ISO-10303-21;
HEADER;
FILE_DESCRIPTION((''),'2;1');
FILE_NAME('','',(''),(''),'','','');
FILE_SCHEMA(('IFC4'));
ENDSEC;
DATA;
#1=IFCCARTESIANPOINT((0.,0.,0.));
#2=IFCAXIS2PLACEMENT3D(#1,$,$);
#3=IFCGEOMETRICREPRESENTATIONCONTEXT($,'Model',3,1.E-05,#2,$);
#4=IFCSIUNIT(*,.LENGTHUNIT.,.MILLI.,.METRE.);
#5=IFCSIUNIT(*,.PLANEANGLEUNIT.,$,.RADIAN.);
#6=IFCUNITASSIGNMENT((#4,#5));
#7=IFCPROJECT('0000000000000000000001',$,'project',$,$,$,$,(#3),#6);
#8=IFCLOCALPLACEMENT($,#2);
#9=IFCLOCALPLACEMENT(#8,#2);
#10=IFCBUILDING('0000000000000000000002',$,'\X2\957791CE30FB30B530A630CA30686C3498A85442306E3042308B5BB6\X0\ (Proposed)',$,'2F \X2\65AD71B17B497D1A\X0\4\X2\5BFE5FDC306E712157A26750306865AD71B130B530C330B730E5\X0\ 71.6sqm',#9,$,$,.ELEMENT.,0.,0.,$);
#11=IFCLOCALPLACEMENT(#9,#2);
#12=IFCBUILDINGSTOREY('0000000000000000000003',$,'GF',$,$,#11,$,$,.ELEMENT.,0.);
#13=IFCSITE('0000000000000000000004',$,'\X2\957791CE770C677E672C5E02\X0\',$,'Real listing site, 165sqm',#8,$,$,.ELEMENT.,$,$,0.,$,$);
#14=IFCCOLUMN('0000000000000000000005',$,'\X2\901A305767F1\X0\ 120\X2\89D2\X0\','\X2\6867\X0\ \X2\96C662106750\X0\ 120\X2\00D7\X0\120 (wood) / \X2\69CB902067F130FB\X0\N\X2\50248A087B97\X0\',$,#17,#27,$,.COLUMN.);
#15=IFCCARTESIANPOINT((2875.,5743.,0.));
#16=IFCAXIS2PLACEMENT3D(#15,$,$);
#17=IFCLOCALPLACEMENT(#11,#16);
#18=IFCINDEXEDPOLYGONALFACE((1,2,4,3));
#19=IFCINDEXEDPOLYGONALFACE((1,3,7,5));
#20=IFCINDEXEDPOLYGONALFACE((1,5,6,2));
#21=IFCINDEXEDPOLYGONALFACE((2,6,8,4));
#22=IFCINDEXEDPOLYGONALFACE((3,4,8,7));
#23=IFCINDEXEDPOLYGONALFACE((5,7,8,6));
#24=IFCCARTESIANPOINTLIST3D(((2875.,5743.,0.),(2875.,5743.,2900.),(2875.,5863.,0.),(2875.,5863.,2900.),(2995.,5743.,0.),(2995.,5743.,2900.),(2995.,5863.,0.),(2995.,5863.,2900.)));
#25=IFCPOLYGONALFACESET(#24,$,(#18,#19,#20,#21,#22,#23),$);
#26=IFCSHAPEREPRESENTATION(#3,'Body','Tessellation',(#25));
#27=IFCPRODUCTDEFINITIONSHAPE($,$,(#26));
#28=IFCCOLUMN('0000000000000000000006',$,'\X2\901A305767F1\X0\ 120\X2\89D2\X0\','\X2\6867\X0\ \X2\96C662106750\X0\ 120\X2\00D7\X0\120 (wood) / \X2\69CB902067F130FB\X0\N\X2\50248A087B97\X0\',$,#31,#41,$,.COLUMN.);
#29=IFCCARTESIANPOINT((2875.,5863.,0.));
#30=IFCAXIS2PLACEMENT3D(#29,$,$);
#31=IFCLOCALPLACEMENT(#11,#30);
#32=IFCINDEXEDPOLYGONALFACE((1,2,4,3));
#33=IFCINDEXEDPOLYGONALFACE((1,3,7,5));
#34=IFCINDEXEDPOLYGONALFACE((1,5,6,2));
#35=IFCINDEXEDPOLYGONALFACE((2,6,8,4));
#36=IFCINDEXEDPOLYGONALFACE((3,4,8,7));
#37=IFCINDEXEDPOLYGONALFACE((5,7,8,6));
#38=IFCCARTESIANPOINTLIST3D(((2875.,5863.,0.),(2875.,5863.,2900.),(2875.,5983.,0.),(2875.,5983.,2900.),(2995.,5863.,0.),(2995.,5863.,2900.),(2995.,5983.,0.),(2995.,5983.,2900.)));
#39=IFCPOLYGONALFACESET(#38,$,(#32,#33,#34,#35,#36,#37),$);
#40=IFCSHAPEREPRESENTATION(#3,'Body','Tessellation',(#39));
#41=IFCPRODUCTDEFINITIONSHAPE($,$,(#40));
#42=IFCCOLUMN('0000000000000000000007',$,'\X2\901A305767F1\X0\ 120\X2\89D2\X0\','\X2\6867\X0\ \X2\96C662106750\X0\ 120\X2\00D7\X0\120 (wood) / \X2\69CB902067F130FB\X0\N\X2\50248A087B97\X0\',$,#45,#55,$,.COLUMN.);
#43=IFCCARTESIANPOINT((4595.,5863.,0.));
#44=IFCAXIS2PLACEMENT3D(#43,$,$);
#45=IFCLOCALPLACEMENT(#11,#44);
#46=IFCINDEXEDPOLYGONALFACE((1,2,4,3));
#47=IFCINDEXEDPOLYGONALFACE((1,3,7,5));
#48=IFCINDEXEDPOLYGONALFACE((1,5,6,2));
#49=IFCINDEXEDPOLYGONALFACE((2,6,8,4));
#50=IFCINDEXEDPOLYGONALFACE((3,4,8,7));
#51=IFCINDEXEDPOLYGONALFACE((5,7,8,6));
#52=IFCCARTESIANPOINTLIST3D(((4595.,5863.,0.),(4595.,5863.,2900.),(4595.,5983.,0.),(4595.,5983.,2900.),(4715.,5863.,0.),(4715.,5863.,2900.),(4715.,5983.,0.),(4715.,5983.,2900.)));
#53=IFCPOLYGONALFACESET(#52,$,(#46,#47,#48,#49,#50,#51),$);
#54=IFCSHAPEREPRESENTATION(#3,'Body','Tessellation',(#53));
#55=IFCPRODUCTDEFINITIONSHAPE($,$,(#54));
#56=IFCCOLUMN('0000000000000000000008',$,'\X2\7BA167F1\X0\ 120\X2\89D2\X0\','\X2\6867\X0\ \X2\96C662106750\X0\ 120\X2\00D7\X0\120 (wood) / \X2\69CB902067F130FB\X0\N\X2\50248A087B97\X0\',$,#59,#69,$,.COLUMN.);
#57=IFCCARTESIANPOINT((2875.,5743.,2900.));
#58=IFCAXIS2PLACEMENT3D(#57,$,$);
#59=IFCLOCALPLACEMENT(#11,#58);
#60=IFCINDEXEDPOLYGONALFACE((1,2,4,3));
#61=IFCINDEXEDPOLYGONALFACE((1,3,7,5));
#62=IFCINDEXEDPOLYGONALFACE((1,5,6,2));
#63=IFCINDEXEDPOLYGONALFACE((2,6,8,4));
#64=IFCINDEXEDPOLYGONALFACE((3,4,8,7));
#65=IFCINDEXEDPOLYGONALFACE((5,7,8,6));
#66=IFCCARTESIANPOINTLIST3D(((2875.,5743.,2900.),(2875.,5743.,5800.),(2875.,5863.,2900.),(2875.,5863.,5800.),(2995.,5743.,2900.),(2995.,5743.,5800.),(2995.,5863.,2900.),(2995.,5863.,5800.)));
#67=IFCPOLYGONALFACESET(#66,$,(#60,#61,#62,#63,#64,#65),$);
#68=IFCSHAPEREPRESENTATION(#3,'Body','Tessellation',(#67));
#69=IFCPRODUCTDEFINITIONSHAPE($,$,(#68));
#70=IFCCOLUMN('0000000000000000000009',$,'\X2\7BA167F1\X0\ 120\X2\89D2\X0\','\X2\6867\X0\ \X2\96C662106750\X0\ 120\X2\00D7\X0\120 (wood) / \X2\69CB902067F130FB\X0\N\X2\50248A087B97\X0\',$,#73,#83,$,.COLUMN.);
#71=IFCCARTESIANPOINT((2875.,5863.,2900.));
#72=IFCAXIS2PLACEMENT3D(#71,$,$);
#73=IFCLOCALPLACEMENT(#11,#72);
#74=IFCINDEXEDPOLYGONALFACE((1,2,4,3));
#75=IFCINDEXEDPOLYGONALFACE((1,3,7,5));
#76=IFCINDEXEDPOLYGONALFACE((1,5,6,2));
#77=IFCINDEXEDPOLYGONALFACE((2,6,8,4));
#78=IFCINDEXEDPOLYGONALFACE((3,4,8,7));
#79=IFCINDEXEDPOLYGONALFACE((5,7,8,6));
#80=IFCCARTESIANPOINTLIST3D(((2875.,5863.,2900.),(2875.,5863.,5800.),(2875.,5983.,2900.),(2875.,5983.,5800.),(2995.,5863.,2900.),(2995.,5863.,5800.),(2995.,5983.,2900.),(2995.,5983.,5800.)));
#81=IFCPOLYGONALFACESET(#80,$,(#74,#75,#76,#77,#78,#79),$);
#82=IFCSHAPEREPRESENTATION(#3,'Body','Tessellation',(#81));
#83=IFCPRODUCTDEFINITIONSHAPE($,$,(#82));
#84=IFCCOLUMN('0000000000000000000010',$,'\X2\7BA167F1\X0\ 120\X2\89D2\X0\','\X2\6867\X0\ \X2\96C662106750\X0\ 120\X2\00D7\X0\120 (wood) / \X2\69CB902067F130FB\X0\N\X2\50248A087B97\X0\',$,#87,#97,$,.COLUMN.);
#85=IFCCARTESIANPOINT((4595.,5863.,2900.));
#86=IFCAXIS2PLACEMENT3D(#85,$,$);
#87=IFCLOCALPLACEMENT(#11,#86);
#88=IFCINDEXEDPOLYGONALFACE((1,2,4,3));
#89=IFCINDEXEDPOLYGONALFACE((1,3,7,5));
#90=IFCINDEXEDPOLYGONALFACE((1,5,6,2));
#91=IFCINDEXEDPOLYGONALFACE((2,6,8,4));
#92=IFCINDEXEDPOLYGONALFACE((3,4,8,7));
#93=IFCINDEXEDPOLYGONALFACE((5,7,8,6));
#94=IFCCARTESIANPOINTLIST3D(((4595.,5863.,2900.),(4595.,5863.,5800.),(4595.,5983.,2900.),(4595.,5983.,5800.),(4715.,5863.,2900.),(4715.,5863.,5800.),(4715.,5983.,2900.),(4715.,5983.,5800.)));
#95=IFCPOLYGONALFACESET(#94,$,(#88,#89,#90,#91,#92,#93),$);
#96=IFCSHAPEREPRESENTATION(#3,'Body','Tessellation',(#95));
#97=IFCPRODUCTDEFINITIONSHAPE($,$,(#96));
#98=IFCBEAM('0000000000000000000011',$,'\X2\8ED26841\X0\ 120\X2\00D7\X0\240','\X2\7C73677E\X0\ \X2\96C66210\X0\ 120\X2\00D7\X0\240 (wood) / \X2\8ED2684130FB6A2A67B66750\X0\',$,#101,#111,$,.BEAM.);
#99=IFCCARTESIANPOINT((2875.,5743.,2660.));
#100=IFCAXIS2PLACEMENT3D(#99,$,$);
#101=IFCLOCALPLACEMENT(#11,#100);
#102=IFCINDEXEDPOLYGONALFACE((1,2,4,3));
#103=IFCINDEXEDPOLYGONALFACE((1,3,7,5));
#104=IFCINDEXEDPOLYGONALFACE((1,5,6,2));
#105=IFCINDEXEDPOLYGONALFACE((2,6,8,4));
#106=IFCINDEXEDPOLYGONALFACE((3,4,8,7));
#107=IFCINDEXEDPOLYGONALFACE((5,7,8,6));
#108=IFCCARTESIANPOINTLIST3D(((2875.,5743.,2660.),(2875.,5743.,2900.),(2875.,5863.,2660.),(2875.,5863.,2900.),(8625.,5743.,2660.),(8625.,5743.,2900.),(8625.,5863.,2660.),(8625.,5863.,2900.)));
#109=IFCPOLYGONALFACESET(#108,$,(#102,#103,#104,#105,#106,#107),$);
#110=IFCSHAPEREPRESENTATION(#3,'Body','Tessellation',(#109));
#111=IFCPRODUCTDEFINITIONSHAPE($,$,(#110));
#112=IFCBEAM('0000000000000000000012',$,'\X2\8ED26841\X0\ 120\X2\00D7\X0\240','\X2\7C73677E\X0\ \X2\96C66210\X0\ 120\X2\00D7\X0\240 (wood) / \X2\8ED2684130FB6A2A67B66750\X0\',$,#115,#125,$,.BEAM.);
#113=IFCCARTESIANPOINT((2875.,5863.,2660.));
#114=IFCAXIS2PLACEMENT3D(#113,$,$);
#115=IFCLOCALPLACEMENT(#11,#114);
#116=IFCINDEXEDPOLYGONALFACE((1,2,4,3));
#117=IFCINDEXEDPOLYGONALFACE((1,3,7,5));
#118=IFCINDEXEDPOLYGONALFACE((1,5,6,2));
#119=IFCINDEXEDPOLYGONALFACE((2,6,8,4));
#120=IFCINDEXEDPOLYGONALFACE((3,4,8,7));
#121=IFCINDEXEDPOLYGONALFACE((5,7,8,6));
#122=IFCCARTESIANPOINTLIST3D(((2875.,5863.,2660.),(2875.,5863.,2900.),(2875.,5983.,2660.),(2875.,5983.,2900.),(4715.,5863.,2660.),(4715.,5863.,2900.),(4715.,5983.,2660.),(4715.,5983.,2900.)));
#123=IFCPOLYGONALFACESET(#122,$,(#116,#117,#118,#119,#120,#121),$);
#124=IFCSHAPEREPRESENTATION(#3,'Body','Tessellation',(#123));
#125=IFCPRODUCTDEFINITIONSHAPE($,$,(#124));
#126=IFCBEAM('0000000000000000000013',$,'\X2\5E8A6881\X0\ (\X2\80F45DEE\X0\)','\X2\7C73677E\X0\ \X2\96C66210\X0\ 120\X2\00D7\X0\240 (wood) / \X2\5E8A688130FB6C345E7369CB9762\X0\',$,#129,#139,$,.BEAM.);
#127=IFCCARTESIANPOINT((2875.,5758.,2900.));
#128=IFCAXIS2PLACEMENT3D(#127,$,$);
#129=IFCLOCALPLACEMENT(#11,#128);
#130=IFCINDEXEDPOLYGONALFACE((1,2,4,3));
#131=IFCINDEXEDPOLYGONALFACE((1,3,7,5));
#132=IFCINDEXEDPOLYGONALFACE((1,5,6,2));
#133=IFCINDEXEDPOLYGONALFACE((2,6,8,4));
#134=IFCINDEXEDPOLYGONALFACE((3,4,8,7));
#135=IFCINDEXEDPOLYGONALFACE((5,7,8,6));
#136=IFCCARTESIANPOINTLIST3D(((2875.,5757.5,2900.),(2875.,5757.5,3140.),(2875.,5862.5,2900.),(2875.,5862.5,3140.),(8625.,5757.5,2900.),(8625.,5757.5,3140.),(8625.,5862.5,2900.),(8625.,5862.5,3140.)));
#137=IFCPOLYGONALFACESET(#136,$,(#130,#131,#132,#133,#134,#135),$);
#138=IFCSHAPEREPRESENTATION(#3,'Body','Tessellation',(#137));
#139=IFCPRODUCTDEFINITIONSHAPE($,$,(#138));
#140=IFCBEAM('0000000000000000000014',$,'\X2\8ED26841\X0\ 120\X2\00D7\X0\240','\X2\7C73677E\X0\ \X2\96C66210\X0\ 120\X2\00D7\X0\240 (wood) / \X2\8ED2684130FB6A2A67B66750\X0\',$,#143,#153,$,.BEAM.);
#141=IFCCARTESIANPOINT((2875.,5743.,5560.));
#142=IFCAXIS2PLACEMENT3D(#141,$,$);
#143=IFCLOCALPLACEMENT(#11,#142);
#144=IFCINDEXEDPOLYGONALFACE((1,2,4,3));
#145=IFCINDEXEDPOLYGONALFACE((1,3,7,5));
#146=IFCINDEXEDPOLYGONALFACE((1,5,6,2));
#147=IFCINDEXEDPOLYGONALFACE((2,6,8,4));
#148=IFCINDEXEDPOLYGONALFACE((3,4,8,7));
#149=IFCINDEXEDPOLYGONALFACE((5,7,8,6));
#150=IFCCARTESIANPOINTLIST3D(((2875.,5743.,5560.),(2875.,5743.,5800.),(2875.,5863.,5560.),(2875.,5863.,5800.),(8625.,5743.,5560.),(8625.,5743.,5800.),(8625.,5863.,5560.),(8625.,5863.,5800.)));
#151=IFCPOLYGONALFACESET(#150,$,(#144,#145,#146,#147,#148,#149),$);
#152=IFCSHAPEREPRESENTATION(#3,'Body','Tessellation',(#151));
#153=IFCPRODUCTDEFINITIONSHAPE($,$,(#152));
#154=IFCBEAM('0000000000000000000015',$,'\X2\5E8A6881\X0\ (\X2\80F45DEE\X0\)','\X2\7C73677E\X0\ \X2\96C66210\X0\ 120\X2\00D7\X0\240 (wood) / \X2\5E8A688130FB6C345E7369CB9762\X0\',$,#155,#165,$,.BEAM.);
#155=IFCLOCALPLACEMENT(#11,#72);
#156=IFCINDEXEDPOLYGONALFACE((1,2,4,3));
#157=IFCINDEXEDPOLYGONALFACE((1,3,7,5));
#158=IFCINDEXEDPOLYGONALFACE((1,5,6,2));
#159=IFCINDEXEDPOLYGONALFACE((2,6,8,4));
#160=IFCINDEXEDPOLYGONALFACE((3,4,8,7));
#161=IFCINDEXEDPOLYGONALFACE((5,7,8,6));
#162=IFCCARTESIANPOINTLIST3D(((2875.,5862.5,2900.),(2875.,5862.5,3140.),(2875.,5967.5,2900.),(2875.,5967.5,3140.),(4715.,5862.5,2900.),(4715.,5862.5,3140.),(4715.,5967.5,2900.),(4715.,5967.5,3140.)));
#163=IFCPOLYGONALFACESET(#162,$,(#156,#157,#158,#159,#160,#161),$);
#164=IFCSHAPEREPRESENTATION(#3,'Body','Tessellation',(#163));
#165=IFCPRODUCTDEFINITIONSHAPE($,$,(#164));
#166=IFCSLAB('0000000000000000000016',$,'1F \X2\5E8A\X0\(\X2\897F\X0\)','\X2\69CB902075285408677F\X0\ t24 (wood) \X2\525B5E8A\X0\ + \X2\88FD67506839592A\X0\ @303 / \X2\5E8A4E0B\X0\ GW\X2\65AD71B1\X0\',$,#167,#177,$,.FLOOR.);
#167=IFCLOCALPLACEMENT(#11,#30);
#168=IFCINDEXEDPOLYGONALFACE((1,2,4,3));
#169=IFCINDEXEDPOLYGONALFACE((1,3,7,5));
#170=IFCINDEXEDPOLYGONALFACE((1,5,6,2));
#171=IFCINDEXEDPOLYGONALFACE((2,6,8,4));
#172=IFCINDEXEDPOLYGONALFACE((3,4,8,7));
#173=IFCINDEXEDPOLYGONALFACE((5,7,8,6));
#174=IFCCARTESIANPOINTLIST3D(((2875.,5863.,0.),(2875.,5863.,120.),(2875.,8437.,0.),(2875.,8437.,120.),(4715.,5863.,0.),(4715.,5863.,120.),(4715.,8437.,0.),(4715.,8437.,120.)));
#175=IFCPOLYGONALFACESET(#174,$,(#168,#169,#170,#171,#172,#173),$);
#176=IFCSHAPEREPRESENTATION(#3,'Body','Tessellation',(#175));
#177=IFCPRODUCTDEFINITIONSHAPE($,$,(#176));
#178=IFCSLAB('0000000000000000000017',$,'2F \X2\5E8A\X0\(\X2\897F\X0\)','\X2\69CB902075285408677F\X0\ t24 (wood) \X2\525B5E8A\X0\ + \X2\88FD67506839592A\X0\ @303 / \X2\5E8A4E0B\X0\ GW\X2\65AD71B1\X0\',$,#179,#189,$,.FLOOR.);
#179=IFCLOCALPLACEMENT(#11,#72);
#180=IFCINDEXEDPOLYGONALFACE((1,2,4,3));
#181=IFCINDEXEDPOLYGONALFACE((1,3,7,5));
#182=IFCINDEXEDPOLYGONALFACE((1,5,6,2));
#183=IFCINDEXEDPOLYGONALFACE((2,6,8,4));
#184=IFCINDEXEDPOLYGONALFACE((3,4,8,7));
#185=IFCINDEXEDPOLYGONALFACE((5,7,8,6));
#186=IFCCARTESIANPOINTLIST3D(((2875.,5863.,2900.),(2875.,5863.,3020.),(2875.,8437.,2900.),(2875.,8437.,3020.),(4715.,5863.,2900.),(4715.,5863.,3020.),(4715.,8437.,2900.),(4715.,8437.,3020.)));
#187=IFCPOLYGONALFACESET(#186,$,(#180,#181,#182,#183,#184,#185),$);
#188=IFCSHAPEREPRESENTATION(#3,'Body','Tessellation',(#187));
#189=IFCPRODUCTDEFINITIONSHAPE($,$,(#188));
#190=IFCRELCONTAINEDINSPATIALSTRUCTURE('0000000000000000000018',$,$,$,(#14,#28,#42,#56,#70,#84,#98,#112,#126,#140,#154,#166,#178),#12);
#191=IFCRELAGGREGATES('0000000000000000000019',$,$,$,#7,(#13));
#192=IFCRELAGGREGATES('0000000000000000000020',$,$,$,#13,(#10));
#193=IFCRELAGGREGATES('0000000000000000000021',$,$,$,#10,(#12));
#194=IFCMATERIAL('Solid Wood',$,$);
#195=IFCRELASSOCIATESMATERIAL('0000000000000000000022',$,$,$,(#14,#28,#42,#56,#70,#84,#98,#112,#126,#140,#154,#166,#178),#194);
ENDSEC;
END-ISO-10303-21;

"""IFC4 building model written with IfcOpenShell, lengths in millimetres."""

from ifc_helpers import new_model, si_unit, frame, frame_2d, origin, place, context, project, spatial, rectangle, extrude, material, element, save


model = new_model("IFC4")

# Units and contexts
model_context = context("Model", 3, precision=1e-05, world=origin())
ifc_project = project(units=[si_unit("LENGTHUNIT", "METRE", prefix="MILLI"), si_unit("PLANEANGLEUNIT", "RADIAN")], contexts=[model_context])

# Site, building, storey
site_placement = place(None, origin())
site = spatial("IfcSite", under=ifc_project, at=site_placement, Name="長野県松本市", ObjectType="Real listing site, 165sqm", CompositionType="ELEMENT", RefElevation=0.0)
building_placement = place(site_placement, origin())
building = spatial("IfcBuilding", under=site, at=building_placement, Name="長野・サウナと水風呂のある家 (Proposed)", ObjectType="2F 断熱等級4対応の無垢材と断熱サッシュ 71.6sqm", CompositionType="ELEMENT", ElevationOfRefHeight=0.0, ElevationOfTerrain=0.0)
storey_placement = place(building_placement, origin())
storey = spatial("IfcBuildingStorey", under=building, at=storey_placement, Name="GF", CompositionType="ELEMENT", Elevation=0.0)

# Columns
ifc_material_1 = material(Name="Solid Wood")
column_1_placement = place(storey_placement, frame((2875.0, 5743.0, 0.0)))
element("IfcColumn", 1, at=column_1_placement, inside=storey, material=ifc_material_1, Name="通し柱 120角", Description="桧 集成材 120×120 (wood) / 構造柱・N値計算", PredefinedType="COLUMN", context=model_context, shape_type="SweptSolid", body=[
    extrude(rectangle(XDim=120.0, YDim=120.0, at=frame_2d((60.0, 60.0))), frame((2875.0, 5743.0, 0.0)), (0.0, 0.0, 1.0), 2900.0),
])
column_2_placement = place(storey_placement, frame((2875.0, 5863.0, 0.0)))
element("IfcColumn", 2, at=column_2_placement, inside=storey, material=ifc_material_1, Name="通し柱 120角", Description="桧 集成材 120×120 (wood) / 構造柱・N値計算", PredefinedType="COLUMN", context=model_context, shape_type="SweptSolid", body=[
    extrude(rectangle(XDim=120.0, YDim=120.0, at=frame_2d((60.0, 60.0))), frame((2875.0, 5863.0, 0.0)), (0.0, 0.0, 1.0), 2900.0),
])
column_3_placement = place(storey_placement, frame((4595.0, 5863.0, 0.0)))
element("IfcColumn", 3, at=column_3_placement, inside=storey, material=ifc_material_1, Name="通し柱 120角", Description="桧 集成材 120×120 (wood) / 構造柱・N値計算", PredefinedType="COLUMN", context=model_context, shape_type="SweptSolid", body=[
    extrude(rectangle(XDim=120.0, YDim=120.0, at=frame_2d((60.0, 60.0))), frame((4595.0, 5863.0, 0.0)), (0.0, 0.0, 1.0), 2900.0),
])
column_4_placement = place(storey_placement, frame((2875.0, 5743.0, 2900.0)))
element("IfcColumn", 4, at=column_4_placement, inside=storey, material=ifc_material_1, Name="管柱 120角", Description="桧 集成材 120×120 (wood) / 構造柱・N値計算", PredefinedType="COLUMN", context=model_context, shape_type="SweptSolid", body=[
    extrude(rectangle(XDim=120.0, YDim=120.0, at=frame_2d((60.0, 60.0))), frame((2875.0, 5743.0, 2900.0)), (0.0, 0.0, 1.0), 2900.0),
])
column_5_placement = place(storey_placement, frame((2875.0, 5863.0, 2900.0)))
element("IfcColumn", 5, at=column_5_placement, inside=storey, material=ifc_material_1, Name="管柱 120角", Description="桧 集成材 120×120 (wood) / 構造柱・N値計算", PredefinedType="COLUMN", context=model_context, shape_type="SweptSolid", body=[
    extrude(rectangle(XDim=120.0, YDim=120.0, at=frame_2d((60.0, 60.0))), frame((2875.0, 5863.0, 2900.0)), (0.0, 0.0, 1.0), 2900.0),
])
column_6_placement = place(storey_placement, frame((4595.0, 5863.0, 2900.0)))
element("IfcColumn", 6, at=column_6_placement, inside=storey, material=ifc_material_1, Name="管柱 120角", Description="桧 集成材 120×120 (wood) / 構造柱・N値計算", PredefinedType="COLUMN", context=model_context, shape_type="SweptSolid", body=[
    extrude(rectangle(XDim=120.0, YDim=120.0, at=frame_2d((60.0, 60.0))), frame((4595.0, 5863.0, 2900.0)), (0.0, 0.0, 1.0), 2900.0),
])

# Beams
beam_1_placement = place(storey_placement, frame((2875.0, 5743.0, 2660.0)))
element("IfcBeam", 7, at=beam_1_placement, inside=storey, material=ifc_material_1, Name="軒桁 120×240", Description="米松 集成 120×240 (wood) / 軒桁・横架材", PredefinedType="BEAM", context=model_context, shape_type="SweptSolid", body=[
    extrude(rectangle(XDim=5750.0, YDim=120.0, at=frame_2d((2875.0, 60.0))), frame((2875.0, 5743.0, 2660.0)), (0.0, 0.0, 1.0), 240.0),
])
beam_2_placement = place(storey_placement, frame((2875.0, 5863.0, 2660.0)))
element("IfcBeam", 8, at=beam_2_placement, inside=storey, material=ifc_material_1, Name="軒桁 120×240", Description="米松 集成 120×240 (wood) / 軒桁・横架材", PredefinedType="BEAM", context=model_context, shape_type="SweptSolid", body=[
    extrude(rectangle(XDim=1840.0, YDim=120.0, at=frame_2d((920.0, 60.0))), frame((2875.0, 5863.0, 2660.0)), (0.0, 0.0, 1.0), 240.0),
])
beam_3_placement = place(storey_placement, frame((2875.0, 5758.0, 2900.0)))
element("IfcBeam", 9, at=beam_3_placement, inside=storey, material=ifc_material_1, Name="床梁 (胴差)", Description="米松 集成 120×240 (wood) / 床梁・水平構面", PredefinedType="BEAM", context=model_context, shape_type="SweptSolid", body=[
    extrude(rectangle(XDim=5750.0, YDim=105.0, at=frame_2d((2875.0, 52.0))), frame((2875.0, 5758.0, 2900.0)), (0.0, 0.0, 1.0), 240.0),
])
beam_4_placement = place(storey_placement, frame((2875.0, 5743.0, 5560.0)))
element("IfcBeam", 10, at=beam_4_placement, inside=storey, material=ifc_material_1, Name="軒桁 120×240", Description="米松 集成 120×240 (wood) / 軒桁・横架材", PredefinedType="BEAM", context=model_context, shape_type="SweptSolid", body=[
    extrude(rectangle(XDim=5750.0, YDim=120.0, at=frame_2d((2875.0, 60.0))), frame((2875.0, 5743.0, 5560.0)), (0.0, 0.0, 1.0), 240.0),
])
beam_5_placement = place(storey_placement, frame((2875.0, 5863.0, 2900.0)))
element("IfcBeam", 11, at=beam_5_placement, inside=storey, material=ifc_material_1, Name="床梁 (胴差)", Description="米松 集成 120×240 (wood) / 床梁・水平構面", PredefinedType="BEAM", context=model_context, shape_type="SweptSolid", body=[
    extrude(rectangle(XDim=1840.0, YDim=105.0, at=frame_2d((920.0, 52.0))), frame((2875.0, 5863.0, 2900.0)), (0.0, 0.0, 1.0), 240.0),
])

# Slabs
slab_1_placement = place(storey_placement, frame((2875.0, 5863.0, 0.0)))
element("IfcSlab", 12, at=slab_1_placement, inside=storey, material=ifc_material_1, Name="1F 床(西)", Description="構造用合板 t24 (wood) 剛床 + 製材根太 @303 / 床下 GW断熱", PredefinedType="FLOOR", context=model_context, shape_type="SweptSolid", body=[
    extrude(rectangle(XDim=1840.0, YDim=2574.0, at=frame_2d((920.0, 1287.0))), frame((2875.0, 5863.0, 0.0)), (0.0, 0.0, 1.0), 120.0),
])
slab_2_placement = place(storey_placement, frame((2875.0, 5863.0, 2900.0)))
element("IfcSlab", 13, at=slab_2_placement, inside=storey, material=ifc_material_1, Name="2F 床(西)", Description="構造用合板 t24 (wood) 剛床 + 製材根太 @303 / 床下 GW断熱", PredefinedType="FLOOR", context=model_context, shape_type="SweptSolid", body=[
    extrude(rectangle(XDim=1840.0, YDim=2574.0, at=frame_2d((920.0, 1287.0))), frame((2875.0, 5863.0, 2900.0)), (0.0, 0.0, 1.0), 120.0),
])

save(model, "model.ifc")
